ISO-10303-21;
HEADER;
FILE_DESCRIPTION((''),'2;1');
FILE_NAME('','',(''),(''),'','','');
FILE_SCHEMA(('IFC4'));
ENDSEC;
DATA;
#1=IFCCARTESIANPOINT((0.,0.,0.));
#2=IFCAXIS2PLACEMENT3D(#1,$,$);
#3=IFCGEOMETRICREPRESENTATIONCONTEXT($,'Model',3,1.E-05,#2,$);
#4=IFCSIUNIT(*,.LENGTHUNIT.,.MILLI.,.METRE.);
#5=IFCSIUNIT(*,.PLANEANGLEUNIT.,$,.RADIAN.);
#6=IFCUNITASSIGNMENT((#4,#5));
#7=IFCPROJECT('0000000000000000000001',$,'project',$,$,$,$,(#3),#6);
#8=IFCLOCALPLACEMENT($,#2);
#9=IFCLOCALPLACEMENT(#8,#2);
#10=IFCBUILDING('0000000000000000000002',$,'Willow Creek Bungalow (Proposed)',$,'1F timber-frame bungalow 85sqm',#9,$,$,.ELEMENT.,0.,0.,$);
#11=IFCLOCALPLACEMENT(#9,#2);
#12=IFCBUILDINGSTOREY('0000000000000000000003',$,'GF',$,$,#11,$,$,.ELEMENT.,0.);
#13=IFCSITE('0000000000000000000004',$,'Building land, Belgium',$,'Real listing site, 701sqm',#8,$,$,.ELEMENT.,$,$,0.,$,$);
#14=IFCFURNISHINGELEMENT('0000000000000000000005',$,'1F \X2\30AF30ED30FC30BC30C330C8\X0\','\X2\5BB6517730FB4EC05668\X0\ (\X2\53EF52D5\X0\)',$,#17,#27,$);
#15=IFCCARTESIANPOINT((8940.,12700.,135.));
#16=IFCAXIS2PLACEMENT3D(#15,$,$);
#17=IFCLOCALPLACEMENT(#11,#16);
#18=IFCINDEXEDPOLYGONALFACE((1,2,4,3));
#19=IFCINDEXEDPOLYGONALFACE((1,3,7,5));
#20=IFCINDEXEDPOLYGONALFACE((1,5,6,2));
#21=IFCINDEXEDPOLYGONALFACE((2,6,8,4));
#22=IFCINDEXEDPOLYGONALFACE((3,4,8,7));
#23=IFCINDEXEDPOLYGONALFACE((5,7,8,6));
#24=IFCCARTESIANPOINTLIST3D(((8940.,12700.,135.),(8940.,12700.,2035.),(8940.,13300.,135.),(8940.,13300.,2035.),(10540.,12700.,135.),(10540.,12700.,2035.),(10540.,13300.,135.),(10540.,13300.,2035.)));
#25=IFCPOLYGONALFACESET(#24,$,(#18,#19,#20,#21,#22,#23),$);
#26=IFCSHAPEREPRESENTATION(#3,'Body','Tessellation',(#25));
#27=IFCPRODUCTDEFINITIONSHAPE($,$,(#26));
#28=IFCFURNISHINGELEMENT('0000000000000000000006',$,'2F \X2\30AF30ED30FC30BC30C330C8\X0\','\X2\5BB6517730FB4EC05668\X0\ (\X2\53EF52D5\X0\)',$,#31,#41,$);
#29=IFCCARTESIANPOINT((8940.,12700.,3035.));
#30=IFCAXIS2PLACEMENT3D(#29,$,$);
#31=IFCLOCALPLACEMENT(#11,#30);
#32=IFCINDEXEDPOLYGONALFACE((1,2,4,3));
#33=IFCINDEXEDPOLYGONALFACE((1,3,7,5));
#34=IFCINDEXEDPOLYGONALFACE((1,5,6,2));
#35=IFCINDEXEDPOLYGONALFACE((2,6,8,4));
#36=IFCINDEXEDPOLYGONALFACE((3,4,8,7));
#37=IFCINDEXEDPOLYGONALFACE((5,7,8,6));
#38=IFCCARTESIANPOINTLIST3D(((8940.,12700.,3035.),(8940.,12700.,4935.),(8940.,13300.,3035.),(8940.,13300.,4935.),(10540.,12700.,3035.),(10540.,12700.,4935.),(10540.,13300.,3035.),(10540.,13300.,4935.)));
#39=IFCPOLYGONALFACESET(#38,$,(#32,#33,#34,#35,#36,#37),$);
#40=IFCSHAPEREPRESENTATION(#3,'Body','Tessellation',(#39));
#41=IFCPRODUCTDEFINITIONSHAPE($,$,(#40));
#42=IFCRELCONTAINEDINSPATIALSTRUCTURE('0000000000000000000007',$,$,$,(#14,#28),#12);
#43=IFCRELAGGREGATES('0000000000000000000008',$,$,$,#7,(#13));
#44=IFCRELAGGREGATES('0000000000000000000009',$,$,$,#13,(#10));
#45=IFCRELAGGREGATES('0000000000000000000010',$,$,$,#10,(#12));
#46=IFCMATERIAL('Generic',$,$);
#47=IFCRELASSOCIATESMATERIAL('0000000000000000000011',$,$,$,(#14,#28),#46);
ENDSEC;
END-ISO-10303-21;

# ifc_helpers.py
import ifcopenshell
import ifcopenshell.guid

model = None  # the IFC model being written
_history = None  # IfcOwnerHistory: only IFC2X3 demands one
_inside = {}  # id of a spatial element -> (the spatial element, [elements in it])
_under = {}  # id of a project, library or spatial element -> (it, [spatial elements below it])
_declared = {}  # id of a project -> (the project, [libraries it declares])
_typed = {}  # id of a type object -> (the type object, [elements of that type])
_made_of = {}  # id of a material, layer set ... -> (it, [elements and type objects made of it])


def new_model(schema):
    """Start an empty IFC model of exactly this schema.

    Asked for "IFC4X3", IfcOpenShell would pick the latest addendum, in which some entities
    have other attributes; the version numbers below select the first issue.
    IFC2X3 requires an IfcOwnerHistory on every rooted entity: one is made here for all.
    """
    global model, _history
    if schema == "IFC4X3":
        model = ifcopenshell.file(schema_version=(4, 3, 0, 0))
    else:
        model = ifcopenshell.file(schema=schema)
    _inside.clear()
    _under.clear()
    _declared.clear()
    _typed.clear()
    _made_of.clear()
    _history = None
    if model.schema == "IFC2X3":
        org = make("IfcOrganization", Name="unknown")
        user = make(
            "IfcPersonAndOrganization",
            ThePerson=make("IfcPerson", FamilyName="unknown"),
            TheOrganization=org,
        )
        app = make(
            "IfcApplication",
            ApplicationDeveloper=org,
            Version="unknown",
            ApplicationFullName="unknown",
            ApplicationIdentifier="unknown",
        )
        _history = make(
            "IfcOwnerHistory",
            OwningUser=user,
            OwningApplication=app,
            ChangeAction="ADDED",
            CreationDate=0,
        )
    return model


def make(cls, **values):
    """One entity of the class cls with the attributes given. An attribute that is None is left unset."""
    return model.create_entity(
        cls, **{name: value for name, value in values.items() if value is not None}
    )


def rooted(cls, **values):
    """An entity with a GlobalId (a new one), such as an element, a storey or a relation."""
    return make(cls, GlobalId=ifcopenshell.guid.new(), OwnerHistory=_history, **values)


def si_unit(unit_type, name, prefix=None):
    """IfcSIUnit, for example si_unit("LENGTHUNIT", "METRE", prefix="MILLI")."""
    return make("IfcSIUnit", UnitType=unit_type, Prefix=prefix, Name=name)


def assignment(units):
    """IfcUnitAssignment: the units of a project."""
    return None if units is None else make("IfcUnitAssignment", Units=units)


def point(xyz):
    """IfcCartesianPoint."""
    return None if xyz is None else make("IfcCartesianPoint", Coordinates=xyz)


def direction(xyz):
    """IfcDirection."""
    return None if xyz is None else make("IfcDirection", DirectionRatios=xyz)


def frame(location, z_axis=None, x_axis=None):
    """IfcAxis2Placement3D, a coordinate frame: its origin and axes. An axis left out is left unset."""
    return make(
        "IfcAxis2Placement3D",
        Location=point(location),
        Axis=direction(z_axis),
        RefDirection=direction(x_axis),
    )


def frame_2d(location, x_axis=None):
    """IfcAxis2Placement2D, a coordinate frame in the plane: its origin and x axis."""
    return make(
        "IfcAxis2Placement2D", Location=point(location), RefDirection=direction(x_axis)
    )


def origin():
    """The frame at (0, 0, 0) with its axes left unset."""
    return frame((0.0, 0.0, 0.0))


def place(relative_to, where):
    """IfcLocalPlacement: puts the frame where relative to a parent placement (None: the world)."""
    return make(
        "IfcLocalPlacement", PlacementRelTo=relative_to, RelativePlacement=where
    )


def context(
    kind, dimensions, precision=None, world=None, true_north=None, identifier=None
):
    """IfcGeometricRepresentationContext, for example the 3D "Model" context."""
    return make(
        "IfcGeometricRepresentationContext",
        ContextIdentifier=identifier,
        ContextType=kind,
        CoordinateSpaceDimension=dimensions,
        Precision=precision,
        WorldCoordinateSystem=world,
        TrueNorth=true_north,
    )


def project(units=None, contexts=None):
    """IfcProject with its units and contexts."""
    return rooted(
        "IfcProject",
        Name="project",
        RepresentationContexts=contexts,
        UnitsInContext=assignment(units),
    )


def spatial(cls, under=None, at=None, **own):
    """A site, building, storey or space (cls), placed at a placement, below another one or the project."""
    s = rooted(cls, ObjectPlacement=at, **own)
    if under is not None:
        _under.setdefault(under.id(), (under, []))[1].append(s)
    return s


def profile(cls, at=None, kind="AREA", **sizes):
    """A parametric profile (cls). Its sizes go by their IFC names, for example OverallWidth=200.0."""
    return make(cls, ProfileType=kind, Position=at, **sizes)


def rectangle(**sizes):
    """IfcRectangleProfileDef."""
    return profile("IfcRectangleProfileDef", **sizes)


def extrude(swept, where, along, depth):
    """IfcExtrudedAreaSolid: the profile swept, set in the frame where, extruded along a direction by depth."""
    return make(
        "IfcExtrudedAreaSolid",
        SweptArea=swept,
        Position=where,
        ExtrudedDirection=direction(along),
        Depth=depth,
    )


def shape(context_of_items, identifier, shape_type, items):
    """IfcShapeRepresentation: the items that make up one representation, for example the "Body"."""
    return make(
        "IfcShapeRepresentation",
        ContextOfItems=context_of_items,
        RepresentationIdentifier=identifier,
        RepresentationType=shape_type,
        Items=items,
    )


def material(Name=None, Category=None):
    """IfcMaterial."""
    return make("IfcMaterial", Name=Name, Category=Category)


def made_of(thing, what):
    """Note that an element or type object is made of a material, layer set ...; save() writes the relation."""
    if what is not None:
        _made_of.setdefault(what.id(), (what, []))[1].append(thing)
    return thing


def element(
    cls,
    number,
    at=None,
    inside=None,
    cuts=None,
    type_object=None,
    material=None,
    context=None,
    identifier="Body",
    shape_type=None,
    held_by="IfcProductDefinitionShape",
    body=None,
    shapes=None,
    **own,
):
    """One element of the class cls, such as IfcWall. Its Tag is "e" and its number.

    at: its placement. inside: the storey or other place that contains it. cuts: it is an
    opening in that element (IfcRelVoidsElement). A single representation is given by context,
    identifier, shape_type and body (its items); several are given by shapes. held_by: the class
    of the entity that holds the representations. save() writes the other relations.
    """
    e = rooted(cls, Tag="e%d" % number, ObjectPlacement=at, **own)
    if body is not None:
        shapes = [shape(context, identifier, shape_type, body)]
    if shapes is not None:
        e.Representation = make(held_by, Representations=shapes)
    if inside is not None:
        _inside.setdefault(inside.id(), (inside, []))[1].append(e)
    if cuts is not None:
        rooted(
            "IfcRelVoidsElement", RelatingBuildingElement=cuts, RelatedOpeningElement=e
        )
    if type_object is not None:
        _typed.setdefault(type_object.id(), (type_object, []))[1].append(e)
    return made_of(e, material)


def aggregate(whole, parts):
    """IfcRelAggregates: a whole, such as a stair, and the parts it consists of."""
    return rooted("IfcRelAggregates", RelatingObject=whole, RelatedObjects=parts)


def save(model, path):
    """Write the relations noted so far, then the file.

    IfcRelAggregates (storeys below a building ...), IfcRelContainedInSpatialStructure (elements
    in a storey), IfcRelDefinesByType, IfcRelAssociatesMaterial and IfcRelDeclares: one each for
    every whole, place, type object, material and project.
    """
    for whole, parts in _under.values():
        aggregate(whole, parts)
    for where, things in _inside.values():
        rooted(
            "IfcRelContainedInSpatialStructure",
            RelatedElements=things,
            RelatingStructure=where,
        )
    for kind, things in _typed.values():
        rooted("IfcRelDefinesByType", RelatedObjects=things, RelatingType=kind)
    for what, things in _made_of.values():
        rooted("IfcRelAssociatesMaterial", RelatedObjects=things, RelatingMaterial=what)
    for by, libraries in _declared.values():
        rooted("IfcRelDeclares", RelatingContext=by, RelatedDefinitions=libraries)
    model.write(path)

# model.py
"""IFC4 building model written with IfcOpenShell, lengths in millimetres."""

from ifc_helpers import new_model, si_unit, frame, frame_2d, origin, place, context, project, spatial, rectangle, extrude, material, element, save


model = new_model("IFC4")

# Units and contexts
model_context = context("Model", 3, precision=1e-05, world=origin())
ifc_project = project(units=[si_unit("LENGTHUNIT", "METRE", prefix="MILLI"), si_unit("PLANEANGLEUNIT", "RADIAN")], contexts=[model_context])

# Site, building, storey
site_placement = place(None, origin())
site = spatial("IfcSite", under=ifc_project, at=site_placement, Name="Building land, Belgium", ObjectType="Real listing site, 701sqm", CompositionType="ELEMENT", RefElevation=0.0)
building_placement = place(site_placement, origin())
building = spatial("IfcBuilding", under=site, at=building_placement, Name="Willow Creek Bungalow (Proposed)", ObjectType="1F timber-frame bungalow 85sqm", CompositionType="ELEMENT", ElevationOfRefHeight=0.0, ElevationOfTerrain=0.0)
storey_placement = place(building_placement, origin())
storey = spatial("IfcBuildingStorey", under=building, at=storey_placement, Name="GF", CompositionType="ELEMENT", Elevation=0.0)

# Shared definitions
ifc_material_1 = material(Name="Generic")

# Furnishing elements
furnishing_1_placement = place(storey_placement, frame((8940.0, 12700.0, 135.0)))
element("IfcFurnishingElement", 1, at=furnishing_1_placement, inside=storey, material=ifc_material_1, Name="1F クローゼット", Description="家具・什器 (可動)", context=model_context, shape_type="SweptSolid", body=[
    extrude(rectangle(XDim=1600.0, YDim=600.0, at=frame_2d((800.0, 300.0))), frame((8940.0, 12700.0, 135.0)), (0.0, 0.0, 1.0), 1900.0),
])
furnishing_2_placement = place(storey_placement, frame((8940.0, 12700.0, 3035.0)))
element("IfcFurnishingElement", 2, at=furnishing_2_placement, inside=storey, material=ifc_material_1, Name="2F クローゼット", Description="家具・什器 (可動)", context=model_context, shape_type="SweptSolid", body=[
    extrude(rectangle(XDim=1600.0, YDim=600.0, at=frame_2d((800.0, 300.0))), frame((8940.0, 12700.0, 3035.0)), (0.0, 0.0, 1.0), 1900.0),
])

save(model, "model.ifc")
